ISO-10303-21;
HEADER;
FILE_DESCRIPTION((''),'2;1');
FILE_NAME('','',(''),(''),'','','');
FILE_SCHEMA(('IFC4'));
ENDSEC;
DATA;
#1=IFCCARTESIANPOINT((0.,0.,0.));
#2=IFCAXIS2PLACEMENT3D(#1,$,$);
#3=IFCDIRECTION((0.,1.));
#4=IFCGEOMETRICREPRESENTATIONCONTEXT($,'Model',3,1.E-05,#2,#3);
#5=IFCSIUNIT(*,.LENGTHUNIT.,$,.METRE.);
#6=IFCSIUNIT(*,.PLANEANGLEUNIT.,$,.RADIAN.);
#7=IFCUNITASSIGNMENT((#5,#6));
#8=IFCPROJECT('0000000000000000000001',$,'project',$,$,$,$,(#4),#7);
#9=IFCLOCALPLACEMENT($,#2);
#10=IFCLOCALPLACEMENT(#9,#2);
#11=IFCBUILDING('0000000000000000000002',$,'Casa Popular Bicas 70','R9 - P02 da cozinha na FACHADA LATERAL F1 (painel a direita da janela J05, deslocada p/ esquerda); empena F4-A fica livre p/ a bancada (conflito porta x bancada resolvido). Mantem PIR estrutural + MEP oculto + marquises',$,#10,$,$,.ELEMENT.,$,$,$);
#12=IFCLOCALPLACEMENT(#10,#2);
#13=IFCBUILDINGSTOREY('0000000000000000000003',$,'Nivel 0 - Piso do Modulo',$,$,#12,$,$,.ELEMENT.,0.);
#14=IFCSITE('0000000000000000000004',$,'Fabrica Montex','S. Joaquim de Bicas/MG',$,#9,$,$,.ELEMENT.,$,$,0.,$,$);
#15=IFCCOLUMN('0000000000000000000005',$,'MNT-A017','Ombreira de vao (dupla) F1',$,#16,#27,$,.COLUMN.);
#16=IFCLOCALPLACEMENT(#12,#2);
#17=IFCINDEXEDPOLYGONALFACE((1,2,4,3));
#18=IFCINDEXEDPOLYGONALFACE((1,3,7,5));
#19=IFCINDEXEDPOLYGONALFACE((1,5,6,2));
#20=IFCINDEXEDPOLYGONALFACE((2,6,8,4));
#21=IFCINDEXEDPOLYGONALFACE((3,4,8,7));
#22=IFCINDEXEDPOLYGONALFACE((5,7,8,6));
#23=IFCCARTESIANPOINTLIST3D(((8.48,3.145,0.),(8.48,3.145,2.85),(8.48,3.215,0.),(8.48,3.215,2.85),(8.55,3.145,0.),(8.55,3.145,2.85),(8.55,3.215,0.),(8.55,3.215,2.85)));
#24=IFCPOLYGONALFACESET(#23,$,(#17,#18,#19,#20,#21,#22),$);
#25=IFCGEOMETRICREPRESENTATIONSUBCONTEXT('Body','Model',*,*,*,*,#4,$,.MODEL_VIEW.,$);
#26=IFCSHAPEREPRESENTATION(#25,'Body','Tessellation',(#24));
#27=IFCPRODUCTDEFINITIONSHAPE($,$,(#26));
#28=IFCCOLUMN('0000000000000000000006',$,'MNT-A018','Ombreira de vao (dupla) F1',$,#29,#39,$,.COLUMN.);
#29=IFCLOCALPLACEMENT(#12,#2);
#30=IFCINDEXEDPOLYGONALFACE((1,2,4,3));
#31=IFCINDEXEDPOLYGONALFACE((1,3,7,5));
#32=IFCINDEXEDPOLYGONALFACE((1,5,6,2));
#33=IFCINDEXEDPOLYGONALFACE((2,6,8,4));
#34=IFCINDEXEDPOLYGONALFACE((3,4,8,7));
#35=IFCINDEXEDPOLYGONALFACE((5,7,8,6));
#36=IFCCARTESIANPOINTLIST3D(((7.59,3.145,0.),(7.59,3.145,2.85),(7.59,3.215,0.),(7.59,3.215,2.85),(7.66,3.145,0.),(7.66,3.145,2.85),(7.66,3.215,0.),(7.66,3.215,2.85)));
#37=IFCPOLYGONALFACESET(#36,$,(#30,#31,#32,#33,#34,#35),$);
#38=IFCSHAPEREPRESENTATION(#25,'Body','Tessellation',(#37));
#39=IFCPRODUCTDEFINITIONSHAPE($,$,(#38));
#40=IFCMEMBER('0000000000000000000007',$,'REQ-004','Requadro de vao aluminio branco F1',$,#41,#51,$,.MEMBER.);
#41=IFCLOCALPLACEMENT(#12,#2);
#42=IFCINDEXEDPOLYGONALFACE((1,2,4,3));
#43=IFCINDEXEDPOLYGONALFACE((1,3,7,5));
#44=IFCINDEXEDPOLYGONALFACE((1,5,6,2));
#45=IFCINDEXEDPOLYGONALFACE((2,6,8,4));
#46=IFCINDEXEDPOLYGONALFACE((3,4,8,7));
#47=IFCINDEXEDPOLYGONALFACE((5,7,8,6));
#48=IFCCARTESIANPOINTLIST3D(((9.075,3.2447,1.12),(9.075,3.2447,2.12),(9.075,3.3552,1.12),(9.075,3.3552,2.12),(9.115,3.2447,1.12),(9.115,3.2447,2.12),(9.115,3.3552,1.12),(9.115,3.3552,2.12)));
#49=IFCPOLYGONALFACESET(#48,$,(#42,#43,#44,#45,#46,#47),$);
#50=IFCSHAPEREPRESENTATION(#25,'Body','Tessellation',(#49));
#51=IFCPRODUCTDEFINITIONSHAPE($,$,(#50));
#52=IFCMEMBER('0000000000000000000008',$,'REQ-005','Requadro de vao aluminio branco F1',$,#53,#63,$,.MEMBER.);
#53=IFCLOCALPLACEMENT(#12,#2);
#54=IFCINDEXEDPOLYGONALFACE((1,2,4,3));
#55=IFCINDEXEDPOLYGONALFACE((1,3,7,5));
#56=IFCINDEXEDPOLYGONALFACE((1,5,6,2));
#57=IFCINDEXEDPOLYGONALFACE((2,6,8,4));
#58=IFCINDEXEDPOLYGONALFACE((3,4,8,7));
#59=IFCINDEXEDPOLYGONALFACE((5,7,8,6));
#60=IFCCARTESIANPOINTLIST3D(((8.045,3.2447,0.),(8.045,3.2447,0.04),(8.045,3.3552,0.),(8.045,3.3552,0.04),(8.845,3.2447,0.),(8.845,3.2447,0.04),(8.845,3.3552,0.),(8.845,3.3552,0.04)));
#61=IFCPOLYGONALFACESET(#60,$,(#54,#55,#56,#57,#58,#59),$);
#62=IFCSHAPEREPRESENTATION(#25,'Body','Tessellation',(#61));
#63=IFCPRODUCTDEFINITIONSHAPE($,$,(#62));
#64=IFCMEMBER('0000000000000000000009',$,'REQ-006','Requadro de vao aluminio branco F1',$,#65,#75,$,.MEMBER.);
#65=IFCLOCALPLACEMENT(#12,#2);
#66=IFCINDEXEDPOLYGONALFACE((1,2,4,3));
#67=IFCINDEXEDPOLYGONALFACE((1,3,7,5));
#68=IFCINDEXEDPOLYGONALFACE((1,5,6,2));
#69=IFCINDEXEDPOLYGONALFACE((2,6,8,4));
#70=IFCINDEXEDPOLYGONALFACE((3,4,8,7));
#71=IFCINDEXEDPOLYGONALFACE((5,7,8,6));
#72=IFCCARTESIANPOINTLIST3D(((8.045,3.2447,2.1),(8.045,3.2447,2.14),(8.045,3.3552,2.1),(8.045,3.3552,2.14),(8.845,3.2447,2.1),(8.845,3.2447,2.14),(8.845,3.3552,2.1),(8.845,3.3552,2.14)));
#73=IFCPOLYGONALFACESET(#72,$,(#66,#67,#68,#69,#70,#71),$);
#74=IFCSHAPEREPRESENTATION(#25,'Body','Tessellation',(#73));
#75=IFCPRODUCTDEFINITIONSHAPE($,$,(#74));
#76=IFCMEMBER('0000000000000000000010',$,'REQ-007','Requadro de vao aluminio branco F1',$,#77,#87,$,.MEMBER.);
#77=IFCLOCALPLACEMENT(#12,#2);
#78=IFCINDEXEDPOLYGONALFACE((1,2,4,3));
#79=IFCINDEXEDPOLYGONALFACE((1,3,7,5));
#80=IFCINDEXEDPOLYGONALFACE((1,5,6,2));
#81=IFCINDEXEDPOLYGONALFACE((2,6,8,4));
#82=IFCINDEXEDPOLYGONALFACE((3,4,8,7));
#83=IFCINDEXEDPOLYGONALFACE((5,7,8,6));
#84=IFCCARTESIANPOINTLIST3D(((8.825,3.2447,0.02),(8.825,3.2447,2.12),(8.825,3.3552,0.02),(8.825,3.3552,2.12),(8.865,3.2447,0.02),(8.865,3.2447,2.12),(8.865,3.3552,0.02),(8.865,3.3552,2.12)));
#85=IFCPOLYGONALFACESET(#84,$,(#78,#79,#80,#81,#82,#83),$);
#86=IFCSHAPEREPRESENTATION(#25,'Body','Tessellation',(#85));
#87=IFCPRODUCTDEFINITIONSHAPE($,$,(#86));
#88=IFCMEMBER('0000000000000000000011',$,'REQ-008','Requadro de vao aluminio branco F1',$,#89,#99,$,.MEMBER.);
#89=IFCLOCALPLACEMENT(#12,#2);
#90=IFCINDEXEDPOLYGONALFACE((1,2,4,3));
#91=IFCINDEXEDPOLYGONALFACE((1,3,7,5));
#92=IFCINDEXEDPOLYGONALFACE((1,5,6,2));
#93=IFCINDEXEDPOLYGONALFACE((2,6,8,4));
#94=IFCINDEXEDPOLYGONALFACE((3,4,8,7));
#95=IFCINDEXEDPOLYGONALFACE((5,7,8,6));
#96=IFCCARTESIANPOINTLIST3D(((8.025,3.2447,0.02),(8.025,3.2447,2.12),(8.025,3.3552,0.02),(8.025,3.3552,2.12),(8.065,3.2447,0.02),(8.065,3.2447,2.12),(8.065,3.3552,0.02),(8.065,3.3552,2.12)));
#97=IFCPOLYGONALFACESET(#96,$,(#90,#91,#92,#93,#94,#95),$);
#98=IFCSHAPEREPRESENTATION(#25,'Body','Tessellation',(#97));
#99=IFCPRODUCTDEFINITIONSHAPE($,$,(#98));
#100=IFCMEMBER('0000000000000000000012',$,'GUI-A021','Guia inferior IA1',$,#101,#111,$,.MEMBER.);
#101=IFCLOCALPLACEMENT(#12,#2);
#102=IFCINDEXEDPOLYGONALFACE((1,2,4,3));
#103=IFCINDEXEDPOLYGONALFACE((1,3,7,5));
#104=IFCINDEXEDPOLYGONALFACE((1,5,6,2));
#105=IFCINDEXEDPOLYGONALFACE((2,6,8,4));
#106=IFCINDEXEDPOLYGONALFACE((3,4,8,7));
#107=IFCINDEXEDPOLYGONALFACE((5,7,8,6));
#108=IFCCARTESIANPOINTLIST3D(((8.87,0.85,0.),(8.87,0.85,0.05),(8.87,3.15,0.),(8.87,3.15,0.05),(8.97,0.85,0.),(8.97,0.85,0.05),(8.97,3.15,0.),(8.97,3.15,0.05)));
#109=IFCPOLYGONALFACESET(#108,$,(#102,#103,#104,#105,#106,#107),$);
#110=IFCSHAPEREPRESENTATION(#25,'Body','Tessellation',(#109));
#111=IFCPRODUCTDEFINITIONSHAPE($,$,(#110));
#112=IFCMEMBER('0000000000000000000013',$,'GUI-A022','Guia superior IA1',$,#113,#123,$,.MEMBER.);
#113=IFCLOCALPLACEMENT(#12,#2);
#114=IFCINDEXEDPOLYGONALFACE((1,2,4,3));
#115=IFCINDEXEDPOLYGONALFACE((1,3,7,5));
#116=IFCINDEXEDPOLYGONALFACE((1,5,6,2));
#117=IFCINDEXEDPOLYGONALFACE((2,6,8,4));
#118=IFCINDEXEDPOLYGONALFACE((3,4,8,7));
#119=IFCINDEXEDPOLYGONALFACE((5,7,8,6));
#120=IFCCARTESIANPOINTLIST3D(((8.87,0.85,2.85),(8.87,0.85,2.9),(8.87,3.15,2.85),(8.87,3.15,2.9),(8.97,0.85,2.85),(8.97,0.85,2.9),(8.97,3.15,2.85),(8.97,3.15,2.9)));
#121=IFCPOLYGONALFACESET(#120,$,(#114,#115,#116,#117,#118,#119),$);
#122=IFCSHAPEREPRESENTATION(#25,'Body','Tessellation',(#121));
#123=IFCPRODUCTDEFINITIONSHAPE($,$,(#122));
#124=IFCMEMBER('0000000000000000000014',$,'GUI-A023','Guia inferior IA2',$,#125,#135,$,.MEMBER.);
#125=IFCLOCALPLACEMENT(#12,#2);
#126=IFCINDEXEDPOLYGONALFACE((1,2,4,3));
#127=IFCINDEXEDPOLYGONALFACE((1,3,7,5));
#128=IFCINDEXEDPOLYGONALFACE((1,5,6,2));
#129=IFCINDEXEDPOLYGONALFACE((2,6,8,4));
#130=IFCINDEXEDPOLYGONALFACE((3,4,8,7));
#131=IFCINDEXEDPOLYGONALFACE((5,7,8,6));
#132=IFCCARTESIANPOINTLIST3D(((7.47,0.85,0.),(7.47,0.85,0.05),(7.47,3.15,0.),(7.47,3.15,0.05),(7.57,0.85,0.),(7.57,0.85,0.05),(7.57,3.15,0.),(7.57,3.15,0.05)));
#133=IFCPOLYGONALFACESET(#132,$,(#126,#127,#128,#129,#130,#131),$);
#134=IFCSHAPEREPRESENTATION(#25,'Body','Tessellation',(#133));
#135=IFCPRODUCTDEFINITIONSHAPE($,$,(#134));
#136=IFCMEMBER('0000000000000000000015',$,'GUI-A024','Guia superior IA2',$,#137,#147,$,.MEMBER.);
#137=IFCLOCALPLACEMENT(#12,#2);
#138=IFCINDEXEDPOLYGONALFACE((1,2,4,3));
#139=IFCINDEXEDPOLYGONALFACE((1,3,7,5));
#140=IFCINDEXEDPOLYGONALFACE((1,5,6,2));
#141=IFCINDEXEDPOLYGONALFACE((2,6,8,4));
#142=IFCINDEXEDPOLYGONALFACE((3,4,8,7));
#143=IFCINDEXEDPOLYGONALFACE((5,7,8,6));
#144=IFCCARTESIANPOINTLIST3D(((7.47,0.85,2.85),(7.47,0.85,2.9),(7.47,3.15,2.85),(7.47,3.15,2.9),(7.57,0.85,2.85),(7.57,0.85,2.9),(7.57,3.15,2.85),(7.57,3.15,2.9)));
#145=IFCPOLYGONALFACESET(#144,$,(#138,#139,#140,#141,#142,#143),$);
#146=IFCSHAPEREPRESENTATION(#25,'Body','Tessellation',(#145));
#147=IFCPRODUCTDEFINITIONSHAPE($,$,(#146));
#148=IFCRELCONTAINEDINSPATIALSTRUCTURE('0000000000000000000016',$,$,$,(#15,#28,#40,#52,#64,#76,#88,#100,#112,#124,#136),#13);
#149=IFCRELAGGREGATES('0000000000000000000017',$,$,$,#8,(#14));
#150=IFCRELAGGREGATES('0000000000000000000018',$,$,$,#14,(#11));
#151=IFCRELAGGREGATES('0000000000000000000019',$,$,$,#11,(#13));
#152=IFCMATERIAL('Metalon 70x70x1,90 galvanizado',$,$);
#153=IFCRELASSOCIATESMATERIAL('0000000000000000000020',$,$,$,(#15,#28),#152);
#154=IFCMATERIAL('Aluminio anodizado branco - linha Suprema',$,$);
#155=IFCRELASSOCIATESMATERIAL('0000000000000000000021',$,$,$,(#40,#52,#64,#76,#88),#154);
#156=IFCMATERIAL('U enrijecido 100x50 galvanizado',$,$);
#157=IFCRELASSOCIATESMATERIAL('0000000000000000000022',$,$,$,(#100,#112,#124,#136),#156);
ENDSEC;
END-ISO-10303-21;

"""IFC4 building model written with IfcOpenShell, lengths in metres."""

from ifc_helpers import new_model, si_unit, direction, frame, origin, origin_2d, place, context, subcontext, project, spatial, rectangle, extrude, material, element, save


model = new_model("IFC4")

# Units and contexts
model_context = context("Model", 3, precision=1e-05, world=origin(), true_north=direction((0.0, 1.0)))
body_context = subcontext(model_context, "Body", "Model", "MODEL_VIEW")
ifc_project = project(units=[si_unit("LENGTHUNIT", "METRE"), si_unit("PLANEANGLEUNIT", "RADIAN")], contexts=[model_context])

# Site, building, storey
site_placement = place(None, origin())
site = spatial("IfcSite", under=ifc_project, at=site_placement, Name="Fabrica Montex", Description="S. Joaquim de Bicas/MG", CompositionType="ELEMENT", RefElevation=0.0)
building_placement = place(site_placement, origin())
building = spatial("IfcBuilding", under=site, at=building_placement, Name="Casa Popular Bicas 70", Description="R9 - P02 da cozinha na FACHADA LATERAL F1 (painel a direita da janela J05, deslocada p/ esquerda); empena F4-A fica livre p/ a bancada (conflito porta x bancada resolvido). Mantem PIR estrutural + MEP oculto + marquises", CompositionType="ELEMENT")
storey_placement = place(building_placement, origin())
storey = spatial("IfcBuildingStorey", under=building, at=storey_placement, Name="Nivel 0 - Piso do Modulo", CompositionType="ELEMENT", Elevation=0.0)

# Columns
ifc_material_1 = material(Name="Metalon 70x70x1,90 galvanizado")
for number, where, z_axis, x_axis, name in (
    (1, (8.515, 3.18, 0.0), (0.0, 0.0, 1.0), (-1.0, 0.0, 0.0), "MNT-A017"),
    (2, (7.625, 3.18, 0.0), (0.0, 0.0, 1.0), (-1.0, 0.0, 0.0), "MNT-A018"),
):
    element("IfcColumn", number, at=place(None, frame(where, z_axis=z_axis, x_axis=x_axis)), inside=storey, material=ifc_material_1, Name=name, Description="Ombreira de vao (dupla) F1", PredefinedType="COLUMN", context=body_context, shape_type="SweptSolid", body=[
        extrude(rectangle(XDim=0.07, YDim=0.07, at=origin_2d()), origin(), (0.0, 0.0, 1.0), 2.85),
    ])

# Members
ifc_material_2 = material(Name="Aluminio anodizado branco - linha Suprema")
member_placement = place(None, frame((9.095, 3.3, 1.12), z_axis=(0.0, 0.0, 1.0), x_axis=(-1.0, 0.0, 0.0)))
element("IfcMember", 3, at=member_placement, inside=storey, material=ifc_material_2, Name="REQ-004", Description="Requadro de vao aluminio branco F1", PredefinedType="MEMBER", context=body_context, shape_type="SweptSolid", body=[
    extrude(rectangle(XDim=0.04, YDim=0.1105, at=origin_2d()), origin(), (0.0, 0.0, 1.0), 1.0),
])
for number, where, z_axis, x_axis, name in (
    (4, (8.845, 3.3, 0.02), (-1.0, 0.0, 0.0), (0.0, 0.0, 1.0), "REQ-005"),
    (5, (8.845, 3.3, 2.12), (-1.0, 0.0, 0.0), (0.0, 0.0, 1.0), "REQ-006"),
):
    element("IfcMember", number, at=place(None, frame(where, z_axis=z_axis, x_axis=x_axis)), inside=storey, material=ifc_material_2, Name=name, Description="Requadro de vao aluminio branco F1", PredefinedType="MEMBER", context=body_context, shape_type="SweptSolid", body=[
        extrude(rectangle(XDim=0.04, YDim=0.1105, at=origin_2d()), origin(), (0.0, 0.0, 1.0), 0.8),
    ])
for number, where, z_axis, x_axis, name in (
    (6, (8.845, 3.3, 0.02), (0.0, 0.0, 1.0), (-1.0, 0.0, 0.0), "REQ-007"),
    (7, (8.045, 3.3, 0.02), (0.0, 0.0, 1.0), (-1.0, 0.0, 0.0), "REQ-008"),
):
    element("IfcMember", number, at=place(None, frame(where, z_axis=z_axis, x_axis=x_axis)), inside=storey, material=ifc_material_2, Name=name, Description="Requadro de vao aluminio branco F1", PredefinedType="MEMBER", context=body_context, shape_type="SweptSolid", body=[
        extrude(rectangle(XDim=0.04, YDim=0.1105, at=origin_2d()), origin(), (0.0, 0.0, 1.0), 2.1),
    ])
ifc_material_3 = material(Name="U enrijecido 100x50 galvanizado")
for number, where, z_axis, x_axis, name, description in (
    (8, (8.92, 3.15, 0.025), (0.0, -1.0, 0.0), (0.0, 0.0, 1.0), "GUI-A021", "Guia inferior IA1"),
    (9, (8.92, 3.15, 2.875), (0.0, -1.0, 0.0), (0.0, 0.0, 1.0), "GUI-A022", "Guia superior IA1"),
    (10, (7.52, 3.15, 0.025), (0.0, -1.0, 0.0), (0.0, 0.0, 1.0), "GUI-A023", "Guia inferior IA2"),
    (11, (7.52, 3.15, 2.875), (0.0, -1.0, 0.0), (0.0, 0.0, 1.0), "GUI-A024", "Guia superior IA2"),
):
    element("IfcMember", number, at=place(None, frame(where, z_axis=z_axis, x_axis=x_axis)), inside=storey, material=ifc_material_3, Name=name, Description=description, PredefinedType="MEMBER", context=body_context, shape_type="SweptSolid", body=[
        extrude(rectangle(XDim=0.05, YDim=0.1, at=origin_2d()), origin(), (0.0, 0.0, 1.0), 2.3),
    ])

save(model, "model.ifc")
